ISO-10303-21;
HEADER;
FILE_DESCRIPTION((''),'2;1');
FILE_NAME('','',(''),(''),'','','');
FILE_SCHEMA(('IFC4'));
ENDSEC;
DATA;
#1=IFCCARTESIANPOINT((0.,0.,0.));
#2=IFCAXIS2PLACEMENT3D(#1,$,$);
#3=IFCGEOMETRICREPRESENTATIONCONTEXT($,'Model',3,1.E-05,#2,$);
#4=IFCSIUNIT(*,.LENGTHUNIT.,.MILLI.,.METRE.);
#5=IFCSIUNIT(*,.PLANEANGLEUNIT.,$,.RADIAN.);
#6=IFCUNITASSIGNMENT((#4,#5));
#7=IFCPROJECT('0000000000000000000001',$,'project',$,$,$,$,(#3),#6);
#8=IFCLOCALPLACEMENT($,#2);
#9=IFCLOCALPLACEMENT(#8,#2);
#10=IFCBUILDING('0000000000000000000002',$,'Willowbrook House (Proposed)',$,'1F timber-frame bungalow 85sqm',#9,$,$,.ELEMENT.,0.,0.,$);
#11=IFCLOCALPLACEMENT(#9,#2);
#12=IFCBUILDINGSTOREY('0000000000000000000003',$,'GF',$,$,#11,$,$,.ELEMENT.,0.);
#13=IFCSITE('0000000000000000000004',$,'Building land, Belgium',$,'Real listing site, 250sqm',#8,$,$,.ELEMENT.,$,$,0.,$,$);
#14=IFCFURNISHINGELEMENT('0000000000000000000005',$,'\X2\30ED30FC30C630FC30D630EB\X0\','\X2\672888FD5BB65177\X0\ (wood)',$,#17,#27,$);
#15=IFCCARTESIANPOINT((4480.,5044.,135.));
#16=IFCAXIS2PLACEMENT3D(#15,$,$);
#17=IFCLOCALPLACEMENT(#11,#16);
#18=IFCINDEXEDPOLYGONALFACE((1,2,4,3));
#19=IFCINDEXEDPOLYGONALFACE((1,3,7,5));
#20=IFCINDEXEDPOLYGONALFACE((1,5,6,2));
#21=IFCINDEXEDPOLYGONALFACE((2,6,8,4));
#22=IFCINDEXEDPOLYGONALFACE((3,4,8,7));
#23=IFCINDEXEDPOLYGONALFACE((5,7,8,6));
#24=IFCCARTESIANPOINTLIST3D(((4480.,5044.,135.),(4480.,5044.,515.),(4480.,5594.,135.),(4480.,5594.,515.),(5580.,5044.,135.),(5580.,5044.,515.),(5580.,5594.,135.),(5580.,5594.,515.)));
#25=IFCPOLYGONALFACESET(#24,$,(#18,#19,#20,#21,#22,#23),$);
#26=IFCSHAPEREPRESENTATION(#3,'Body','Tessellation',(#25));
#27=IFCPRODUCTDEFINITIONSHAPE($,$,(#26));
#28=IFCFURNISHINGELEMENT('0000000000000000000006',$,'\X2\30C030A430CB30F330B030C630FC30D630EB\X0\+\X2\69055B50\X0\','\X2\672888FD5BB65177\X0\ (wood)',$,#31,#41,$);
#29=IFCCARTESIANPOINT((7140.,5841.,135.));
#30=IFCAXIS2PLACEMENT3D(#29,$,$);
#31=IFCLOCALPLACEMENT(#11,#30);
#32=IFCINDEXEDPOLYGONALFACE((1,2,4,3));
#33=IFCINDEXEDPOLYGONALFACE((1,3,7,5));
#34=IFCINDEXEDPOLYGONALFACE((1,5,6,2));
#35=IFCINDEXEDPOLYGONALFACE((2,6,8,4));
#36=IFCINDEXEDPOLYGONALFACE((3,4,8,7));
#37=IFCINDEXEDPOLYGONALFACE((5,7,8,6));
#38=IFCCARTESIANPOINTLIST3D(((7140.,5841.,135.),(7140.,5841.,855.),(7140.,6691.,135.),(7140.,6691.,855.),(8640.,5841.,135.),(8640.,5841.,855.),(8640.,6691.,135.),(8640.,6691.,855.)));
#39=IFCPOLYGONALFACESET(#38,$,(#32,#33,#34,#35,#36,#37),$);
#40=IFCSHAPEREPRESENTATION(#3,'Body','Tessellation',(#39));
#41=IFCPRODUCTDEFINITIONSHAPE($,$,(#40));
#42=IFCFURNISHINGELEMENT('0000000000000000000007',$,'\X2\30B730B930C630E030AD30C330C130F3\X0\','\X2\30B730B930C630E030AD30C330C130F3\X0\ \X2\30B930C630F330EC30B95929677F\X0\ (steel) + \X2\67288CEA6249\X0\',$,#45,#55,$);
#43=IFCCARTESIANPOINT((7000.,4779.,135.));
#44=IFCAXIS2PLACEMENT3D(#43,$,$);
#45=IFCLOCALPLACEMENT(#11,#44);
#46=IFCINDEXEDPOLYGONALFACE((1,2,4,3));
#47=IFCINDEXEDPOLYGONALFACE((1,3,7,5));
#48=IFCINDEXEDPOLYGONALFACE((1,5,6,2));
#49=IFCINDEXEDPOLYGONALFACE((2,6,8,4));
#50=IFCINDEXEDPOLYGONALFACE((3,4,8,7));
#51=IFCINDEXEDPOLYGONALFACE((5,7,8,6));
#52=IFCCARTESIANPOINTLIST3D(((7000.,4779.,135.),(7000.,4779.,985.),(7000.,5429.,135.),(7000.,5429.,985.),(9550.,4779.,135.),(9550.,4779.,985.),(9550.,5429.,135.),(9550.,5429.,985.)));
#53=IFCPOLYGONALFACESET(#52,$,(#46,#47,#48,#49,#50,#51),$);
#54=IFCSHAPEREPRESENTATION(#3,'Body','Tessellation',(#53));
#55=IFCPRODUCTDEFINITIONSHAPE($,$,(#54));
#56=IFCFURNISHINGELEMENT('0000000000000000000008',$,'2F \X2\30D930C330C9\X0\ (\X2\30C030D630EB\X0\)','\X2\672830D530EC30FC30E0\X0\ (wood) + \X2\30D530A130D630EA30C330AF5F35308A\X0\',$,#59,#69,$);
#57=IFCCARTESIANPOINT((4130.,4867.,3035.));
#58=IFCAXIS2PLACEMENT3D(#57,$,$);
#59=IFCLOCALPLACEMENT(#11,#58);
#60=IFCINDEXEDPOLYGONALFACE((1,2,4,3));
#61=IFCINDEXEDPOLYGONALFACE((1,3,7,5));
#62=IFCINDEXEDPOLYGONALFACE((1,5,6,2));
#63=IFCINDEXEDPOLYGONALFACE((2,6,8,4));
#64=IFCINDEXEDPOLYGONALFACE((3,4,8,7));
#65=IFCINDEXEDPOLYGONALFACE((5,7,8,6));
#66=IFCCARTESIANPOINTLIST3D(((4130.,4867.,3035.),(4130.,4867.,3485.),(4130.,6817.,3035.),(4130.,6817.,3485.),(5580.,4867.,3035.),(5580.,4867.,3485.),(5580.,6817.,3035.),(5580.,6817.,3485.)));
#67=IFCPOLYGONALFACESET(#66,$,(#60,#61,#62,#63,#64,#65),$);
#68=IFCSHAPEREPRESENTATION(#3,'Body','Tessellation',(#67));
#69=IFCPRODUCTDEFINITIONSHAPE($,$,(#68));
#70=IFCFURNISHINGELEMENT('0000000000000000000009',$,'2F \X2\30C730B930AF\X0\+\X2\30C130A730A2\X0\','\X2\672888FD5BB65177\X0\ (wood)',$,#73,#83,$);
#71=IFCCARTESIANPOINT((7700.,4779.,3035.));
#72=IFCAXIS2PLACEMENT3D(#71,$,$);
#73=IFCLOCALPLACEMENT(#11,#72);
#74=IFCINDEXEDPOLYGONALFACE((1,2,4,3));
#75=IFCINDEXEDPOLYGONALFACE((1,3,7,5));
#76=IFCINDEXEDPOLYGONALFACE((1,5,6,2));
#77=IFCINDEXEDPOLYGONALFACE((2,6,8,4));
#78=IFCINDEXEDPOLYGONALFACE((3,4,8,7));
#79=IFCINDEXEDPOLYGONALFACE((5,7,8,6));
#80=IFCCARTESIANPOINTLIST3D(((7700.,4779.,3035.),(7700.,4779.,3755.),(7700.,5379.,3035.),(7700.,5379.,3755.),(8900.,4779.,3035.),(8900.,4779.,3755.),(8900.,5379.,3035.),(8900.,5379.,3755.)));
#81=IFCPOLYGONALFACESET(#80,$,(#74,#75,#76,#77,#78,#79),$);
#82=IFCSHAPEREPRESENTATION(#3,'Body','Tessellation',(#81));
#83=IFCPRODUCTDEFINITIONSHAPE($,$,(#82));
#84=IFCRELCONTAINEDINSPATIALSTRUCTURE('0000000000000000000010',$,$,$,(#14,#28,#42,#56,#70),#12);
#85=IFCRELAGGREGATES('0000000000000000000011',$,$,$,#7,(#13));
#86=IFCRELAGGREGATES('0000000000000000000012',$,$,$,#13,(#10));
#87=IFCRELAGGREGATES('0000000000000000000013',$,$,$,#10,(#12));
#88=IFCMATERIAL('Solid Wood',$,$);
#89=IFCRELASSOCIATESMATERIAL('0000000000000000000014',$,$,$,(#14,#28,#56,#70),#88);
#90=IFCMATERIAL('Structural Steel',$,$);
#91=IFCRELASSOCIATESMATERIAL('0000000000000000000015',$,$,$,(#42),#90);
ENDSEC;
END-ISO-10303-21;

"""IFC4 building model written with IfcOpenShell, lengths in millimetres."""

from ifc_helpers import new_model, si_unit, frame, frame_2d, origin, place, context, project, spatial, rectangle, extrude, material, element, save


model = new_model("IFC4")

# Units and contexts
model_context = context("Model", 3, precision=1e-05, world=origin())
ifc_project = project(units=[si_unit("LENGTHUNIT", "METRE", prefix="MILLI"), si_unit("PLANEANGLEUNIT", "RADIAN")], contexts=[model_context])

# Site, building, storey
site_placement = place(None, origin())
site = spatial("IfcSite", under=ifc_project, at=site_placement, Name="Building land, Belgium", ObjectType="Real listing site, 250sqm", CompositionType="ELEMENT", RefElevation=0.0)
building_placement = place(site_placement, origin())
building = spatial("IfcBuilding", under=site, at=building_placement, Name="Willowbrook House (Proposed)", ObjectType="1F timber-frame bungalow 85sqm", CompositionType="ELEMENT", ElevationOfRefHeight=0.0, ElevationOfTerrain=0.0)
storey_placement = place(building_placement, origin())
storey = spatial("IfcBuildingStorey", under=building, at=storey_placement, Name="GF", CompositionType="ELEMENT", Elevation=0.0)

# Shared definitions
ifc_material_1 = material(Name="Solid Wood")

# Shared definitions
ifc_material_2 = material(Name="Structural Steel")

# Furnishing elements
furnishing_1_placement = place(storey_placement, frame((4480.0, 5044.0, 135.0)))
element("IfcFurnishingElement", 1, at=furnishing_1_placement, inside=storey, material=ifc_material_1, Name="ローテーブル", Description="木製家具 (wood)", context=model_context, shape_type="SweptSolid", body=[
    extrude(rectangle(XDim=1100.0, YDim=550.0, at=frame_2d((550.0, 275.0))), frame((4480.0, 5044.0, 135.0)), (0.0, 0.0, 1.0), 380.0),
])
furnishing_2_placement = place(storey_placement, frame((7140.0, 5841.0, 135.0)))
element("IfcFurnishingElement", 2, at=furnishing_2_placement, inside=storey, material=ifc_material_1, Name="ダイニングテーブル+椅子", Description="木製家具 (wood)", context=model_context, shape_type="SweptSolid", body=[
    extrude(rectangle(XDim=1500.0, YDim=850.0, at=frame_2d((750.0, 425.0))), frame((7140.0, 5841.0, 135.0)), (0.0, 0.0, 1.0), 720.0),
])
furnishing_3_placement = place(storey_placement, frame((7000.0, 4779.0, 135.0)))
element("IfcFurnishingElement", 3, at=furnishing_3_placement, inside=storey, material=ifc_material_2, Name="システムキッチン", Description="システムキッチン ステンレス天板 (steel) + 木質扉", context=model_context, shape_type="SweptSolid", body=[
    extrude(rectangle(XDim=2550.0, YDim=650.0, at=frame_2d((1275.0, 325.0))), frame((7000.0, 4779.0, 135.0)), (0.0, 0.0, 1.0), 850.0),
])
furnishing_4_placement = place(storey_placement, frame((4130.0, 4867.0, 3035.0)))
element("IfcFurnishingElement", 4, at=furnishing_4_placement, inside=storey, material=ifc_material_1, Name="2F ベッド (ダブル)", Description="木フレーム (wood) + ファブリック張り", context=model_context, shape_type="SweptSolid", body=[
    extrude(rectangle(XDim=1450.0, YDim=1950.0, at=frame_2d((725.0, 975.0))), frame((4130.0, 4867.0, 3035.0)), (0.0, 0.0, 1.0), 450.0),
])
furnishing_5_placement = place(storey_placement, frame((7700.0, 4779.0, 3035.0)))
element("IfcFurnishingElement", 5, at=furnishing_5_placement, inside=storey, material=ifc_material_1, Name="2F デスク+チェア", Description="木製家具 (wood)", context=model_context, shape_type="SweptSolid", body=[
    extrude(rectangle(XDim=1200.0, YDim=600.0, at=frame_2d((600.0, 300.0))), frame((7700.0, 4779.0, 3035.0)), (0.0, 0.0, 1.0), 720.0),
])

save(model, "model.ifc")
